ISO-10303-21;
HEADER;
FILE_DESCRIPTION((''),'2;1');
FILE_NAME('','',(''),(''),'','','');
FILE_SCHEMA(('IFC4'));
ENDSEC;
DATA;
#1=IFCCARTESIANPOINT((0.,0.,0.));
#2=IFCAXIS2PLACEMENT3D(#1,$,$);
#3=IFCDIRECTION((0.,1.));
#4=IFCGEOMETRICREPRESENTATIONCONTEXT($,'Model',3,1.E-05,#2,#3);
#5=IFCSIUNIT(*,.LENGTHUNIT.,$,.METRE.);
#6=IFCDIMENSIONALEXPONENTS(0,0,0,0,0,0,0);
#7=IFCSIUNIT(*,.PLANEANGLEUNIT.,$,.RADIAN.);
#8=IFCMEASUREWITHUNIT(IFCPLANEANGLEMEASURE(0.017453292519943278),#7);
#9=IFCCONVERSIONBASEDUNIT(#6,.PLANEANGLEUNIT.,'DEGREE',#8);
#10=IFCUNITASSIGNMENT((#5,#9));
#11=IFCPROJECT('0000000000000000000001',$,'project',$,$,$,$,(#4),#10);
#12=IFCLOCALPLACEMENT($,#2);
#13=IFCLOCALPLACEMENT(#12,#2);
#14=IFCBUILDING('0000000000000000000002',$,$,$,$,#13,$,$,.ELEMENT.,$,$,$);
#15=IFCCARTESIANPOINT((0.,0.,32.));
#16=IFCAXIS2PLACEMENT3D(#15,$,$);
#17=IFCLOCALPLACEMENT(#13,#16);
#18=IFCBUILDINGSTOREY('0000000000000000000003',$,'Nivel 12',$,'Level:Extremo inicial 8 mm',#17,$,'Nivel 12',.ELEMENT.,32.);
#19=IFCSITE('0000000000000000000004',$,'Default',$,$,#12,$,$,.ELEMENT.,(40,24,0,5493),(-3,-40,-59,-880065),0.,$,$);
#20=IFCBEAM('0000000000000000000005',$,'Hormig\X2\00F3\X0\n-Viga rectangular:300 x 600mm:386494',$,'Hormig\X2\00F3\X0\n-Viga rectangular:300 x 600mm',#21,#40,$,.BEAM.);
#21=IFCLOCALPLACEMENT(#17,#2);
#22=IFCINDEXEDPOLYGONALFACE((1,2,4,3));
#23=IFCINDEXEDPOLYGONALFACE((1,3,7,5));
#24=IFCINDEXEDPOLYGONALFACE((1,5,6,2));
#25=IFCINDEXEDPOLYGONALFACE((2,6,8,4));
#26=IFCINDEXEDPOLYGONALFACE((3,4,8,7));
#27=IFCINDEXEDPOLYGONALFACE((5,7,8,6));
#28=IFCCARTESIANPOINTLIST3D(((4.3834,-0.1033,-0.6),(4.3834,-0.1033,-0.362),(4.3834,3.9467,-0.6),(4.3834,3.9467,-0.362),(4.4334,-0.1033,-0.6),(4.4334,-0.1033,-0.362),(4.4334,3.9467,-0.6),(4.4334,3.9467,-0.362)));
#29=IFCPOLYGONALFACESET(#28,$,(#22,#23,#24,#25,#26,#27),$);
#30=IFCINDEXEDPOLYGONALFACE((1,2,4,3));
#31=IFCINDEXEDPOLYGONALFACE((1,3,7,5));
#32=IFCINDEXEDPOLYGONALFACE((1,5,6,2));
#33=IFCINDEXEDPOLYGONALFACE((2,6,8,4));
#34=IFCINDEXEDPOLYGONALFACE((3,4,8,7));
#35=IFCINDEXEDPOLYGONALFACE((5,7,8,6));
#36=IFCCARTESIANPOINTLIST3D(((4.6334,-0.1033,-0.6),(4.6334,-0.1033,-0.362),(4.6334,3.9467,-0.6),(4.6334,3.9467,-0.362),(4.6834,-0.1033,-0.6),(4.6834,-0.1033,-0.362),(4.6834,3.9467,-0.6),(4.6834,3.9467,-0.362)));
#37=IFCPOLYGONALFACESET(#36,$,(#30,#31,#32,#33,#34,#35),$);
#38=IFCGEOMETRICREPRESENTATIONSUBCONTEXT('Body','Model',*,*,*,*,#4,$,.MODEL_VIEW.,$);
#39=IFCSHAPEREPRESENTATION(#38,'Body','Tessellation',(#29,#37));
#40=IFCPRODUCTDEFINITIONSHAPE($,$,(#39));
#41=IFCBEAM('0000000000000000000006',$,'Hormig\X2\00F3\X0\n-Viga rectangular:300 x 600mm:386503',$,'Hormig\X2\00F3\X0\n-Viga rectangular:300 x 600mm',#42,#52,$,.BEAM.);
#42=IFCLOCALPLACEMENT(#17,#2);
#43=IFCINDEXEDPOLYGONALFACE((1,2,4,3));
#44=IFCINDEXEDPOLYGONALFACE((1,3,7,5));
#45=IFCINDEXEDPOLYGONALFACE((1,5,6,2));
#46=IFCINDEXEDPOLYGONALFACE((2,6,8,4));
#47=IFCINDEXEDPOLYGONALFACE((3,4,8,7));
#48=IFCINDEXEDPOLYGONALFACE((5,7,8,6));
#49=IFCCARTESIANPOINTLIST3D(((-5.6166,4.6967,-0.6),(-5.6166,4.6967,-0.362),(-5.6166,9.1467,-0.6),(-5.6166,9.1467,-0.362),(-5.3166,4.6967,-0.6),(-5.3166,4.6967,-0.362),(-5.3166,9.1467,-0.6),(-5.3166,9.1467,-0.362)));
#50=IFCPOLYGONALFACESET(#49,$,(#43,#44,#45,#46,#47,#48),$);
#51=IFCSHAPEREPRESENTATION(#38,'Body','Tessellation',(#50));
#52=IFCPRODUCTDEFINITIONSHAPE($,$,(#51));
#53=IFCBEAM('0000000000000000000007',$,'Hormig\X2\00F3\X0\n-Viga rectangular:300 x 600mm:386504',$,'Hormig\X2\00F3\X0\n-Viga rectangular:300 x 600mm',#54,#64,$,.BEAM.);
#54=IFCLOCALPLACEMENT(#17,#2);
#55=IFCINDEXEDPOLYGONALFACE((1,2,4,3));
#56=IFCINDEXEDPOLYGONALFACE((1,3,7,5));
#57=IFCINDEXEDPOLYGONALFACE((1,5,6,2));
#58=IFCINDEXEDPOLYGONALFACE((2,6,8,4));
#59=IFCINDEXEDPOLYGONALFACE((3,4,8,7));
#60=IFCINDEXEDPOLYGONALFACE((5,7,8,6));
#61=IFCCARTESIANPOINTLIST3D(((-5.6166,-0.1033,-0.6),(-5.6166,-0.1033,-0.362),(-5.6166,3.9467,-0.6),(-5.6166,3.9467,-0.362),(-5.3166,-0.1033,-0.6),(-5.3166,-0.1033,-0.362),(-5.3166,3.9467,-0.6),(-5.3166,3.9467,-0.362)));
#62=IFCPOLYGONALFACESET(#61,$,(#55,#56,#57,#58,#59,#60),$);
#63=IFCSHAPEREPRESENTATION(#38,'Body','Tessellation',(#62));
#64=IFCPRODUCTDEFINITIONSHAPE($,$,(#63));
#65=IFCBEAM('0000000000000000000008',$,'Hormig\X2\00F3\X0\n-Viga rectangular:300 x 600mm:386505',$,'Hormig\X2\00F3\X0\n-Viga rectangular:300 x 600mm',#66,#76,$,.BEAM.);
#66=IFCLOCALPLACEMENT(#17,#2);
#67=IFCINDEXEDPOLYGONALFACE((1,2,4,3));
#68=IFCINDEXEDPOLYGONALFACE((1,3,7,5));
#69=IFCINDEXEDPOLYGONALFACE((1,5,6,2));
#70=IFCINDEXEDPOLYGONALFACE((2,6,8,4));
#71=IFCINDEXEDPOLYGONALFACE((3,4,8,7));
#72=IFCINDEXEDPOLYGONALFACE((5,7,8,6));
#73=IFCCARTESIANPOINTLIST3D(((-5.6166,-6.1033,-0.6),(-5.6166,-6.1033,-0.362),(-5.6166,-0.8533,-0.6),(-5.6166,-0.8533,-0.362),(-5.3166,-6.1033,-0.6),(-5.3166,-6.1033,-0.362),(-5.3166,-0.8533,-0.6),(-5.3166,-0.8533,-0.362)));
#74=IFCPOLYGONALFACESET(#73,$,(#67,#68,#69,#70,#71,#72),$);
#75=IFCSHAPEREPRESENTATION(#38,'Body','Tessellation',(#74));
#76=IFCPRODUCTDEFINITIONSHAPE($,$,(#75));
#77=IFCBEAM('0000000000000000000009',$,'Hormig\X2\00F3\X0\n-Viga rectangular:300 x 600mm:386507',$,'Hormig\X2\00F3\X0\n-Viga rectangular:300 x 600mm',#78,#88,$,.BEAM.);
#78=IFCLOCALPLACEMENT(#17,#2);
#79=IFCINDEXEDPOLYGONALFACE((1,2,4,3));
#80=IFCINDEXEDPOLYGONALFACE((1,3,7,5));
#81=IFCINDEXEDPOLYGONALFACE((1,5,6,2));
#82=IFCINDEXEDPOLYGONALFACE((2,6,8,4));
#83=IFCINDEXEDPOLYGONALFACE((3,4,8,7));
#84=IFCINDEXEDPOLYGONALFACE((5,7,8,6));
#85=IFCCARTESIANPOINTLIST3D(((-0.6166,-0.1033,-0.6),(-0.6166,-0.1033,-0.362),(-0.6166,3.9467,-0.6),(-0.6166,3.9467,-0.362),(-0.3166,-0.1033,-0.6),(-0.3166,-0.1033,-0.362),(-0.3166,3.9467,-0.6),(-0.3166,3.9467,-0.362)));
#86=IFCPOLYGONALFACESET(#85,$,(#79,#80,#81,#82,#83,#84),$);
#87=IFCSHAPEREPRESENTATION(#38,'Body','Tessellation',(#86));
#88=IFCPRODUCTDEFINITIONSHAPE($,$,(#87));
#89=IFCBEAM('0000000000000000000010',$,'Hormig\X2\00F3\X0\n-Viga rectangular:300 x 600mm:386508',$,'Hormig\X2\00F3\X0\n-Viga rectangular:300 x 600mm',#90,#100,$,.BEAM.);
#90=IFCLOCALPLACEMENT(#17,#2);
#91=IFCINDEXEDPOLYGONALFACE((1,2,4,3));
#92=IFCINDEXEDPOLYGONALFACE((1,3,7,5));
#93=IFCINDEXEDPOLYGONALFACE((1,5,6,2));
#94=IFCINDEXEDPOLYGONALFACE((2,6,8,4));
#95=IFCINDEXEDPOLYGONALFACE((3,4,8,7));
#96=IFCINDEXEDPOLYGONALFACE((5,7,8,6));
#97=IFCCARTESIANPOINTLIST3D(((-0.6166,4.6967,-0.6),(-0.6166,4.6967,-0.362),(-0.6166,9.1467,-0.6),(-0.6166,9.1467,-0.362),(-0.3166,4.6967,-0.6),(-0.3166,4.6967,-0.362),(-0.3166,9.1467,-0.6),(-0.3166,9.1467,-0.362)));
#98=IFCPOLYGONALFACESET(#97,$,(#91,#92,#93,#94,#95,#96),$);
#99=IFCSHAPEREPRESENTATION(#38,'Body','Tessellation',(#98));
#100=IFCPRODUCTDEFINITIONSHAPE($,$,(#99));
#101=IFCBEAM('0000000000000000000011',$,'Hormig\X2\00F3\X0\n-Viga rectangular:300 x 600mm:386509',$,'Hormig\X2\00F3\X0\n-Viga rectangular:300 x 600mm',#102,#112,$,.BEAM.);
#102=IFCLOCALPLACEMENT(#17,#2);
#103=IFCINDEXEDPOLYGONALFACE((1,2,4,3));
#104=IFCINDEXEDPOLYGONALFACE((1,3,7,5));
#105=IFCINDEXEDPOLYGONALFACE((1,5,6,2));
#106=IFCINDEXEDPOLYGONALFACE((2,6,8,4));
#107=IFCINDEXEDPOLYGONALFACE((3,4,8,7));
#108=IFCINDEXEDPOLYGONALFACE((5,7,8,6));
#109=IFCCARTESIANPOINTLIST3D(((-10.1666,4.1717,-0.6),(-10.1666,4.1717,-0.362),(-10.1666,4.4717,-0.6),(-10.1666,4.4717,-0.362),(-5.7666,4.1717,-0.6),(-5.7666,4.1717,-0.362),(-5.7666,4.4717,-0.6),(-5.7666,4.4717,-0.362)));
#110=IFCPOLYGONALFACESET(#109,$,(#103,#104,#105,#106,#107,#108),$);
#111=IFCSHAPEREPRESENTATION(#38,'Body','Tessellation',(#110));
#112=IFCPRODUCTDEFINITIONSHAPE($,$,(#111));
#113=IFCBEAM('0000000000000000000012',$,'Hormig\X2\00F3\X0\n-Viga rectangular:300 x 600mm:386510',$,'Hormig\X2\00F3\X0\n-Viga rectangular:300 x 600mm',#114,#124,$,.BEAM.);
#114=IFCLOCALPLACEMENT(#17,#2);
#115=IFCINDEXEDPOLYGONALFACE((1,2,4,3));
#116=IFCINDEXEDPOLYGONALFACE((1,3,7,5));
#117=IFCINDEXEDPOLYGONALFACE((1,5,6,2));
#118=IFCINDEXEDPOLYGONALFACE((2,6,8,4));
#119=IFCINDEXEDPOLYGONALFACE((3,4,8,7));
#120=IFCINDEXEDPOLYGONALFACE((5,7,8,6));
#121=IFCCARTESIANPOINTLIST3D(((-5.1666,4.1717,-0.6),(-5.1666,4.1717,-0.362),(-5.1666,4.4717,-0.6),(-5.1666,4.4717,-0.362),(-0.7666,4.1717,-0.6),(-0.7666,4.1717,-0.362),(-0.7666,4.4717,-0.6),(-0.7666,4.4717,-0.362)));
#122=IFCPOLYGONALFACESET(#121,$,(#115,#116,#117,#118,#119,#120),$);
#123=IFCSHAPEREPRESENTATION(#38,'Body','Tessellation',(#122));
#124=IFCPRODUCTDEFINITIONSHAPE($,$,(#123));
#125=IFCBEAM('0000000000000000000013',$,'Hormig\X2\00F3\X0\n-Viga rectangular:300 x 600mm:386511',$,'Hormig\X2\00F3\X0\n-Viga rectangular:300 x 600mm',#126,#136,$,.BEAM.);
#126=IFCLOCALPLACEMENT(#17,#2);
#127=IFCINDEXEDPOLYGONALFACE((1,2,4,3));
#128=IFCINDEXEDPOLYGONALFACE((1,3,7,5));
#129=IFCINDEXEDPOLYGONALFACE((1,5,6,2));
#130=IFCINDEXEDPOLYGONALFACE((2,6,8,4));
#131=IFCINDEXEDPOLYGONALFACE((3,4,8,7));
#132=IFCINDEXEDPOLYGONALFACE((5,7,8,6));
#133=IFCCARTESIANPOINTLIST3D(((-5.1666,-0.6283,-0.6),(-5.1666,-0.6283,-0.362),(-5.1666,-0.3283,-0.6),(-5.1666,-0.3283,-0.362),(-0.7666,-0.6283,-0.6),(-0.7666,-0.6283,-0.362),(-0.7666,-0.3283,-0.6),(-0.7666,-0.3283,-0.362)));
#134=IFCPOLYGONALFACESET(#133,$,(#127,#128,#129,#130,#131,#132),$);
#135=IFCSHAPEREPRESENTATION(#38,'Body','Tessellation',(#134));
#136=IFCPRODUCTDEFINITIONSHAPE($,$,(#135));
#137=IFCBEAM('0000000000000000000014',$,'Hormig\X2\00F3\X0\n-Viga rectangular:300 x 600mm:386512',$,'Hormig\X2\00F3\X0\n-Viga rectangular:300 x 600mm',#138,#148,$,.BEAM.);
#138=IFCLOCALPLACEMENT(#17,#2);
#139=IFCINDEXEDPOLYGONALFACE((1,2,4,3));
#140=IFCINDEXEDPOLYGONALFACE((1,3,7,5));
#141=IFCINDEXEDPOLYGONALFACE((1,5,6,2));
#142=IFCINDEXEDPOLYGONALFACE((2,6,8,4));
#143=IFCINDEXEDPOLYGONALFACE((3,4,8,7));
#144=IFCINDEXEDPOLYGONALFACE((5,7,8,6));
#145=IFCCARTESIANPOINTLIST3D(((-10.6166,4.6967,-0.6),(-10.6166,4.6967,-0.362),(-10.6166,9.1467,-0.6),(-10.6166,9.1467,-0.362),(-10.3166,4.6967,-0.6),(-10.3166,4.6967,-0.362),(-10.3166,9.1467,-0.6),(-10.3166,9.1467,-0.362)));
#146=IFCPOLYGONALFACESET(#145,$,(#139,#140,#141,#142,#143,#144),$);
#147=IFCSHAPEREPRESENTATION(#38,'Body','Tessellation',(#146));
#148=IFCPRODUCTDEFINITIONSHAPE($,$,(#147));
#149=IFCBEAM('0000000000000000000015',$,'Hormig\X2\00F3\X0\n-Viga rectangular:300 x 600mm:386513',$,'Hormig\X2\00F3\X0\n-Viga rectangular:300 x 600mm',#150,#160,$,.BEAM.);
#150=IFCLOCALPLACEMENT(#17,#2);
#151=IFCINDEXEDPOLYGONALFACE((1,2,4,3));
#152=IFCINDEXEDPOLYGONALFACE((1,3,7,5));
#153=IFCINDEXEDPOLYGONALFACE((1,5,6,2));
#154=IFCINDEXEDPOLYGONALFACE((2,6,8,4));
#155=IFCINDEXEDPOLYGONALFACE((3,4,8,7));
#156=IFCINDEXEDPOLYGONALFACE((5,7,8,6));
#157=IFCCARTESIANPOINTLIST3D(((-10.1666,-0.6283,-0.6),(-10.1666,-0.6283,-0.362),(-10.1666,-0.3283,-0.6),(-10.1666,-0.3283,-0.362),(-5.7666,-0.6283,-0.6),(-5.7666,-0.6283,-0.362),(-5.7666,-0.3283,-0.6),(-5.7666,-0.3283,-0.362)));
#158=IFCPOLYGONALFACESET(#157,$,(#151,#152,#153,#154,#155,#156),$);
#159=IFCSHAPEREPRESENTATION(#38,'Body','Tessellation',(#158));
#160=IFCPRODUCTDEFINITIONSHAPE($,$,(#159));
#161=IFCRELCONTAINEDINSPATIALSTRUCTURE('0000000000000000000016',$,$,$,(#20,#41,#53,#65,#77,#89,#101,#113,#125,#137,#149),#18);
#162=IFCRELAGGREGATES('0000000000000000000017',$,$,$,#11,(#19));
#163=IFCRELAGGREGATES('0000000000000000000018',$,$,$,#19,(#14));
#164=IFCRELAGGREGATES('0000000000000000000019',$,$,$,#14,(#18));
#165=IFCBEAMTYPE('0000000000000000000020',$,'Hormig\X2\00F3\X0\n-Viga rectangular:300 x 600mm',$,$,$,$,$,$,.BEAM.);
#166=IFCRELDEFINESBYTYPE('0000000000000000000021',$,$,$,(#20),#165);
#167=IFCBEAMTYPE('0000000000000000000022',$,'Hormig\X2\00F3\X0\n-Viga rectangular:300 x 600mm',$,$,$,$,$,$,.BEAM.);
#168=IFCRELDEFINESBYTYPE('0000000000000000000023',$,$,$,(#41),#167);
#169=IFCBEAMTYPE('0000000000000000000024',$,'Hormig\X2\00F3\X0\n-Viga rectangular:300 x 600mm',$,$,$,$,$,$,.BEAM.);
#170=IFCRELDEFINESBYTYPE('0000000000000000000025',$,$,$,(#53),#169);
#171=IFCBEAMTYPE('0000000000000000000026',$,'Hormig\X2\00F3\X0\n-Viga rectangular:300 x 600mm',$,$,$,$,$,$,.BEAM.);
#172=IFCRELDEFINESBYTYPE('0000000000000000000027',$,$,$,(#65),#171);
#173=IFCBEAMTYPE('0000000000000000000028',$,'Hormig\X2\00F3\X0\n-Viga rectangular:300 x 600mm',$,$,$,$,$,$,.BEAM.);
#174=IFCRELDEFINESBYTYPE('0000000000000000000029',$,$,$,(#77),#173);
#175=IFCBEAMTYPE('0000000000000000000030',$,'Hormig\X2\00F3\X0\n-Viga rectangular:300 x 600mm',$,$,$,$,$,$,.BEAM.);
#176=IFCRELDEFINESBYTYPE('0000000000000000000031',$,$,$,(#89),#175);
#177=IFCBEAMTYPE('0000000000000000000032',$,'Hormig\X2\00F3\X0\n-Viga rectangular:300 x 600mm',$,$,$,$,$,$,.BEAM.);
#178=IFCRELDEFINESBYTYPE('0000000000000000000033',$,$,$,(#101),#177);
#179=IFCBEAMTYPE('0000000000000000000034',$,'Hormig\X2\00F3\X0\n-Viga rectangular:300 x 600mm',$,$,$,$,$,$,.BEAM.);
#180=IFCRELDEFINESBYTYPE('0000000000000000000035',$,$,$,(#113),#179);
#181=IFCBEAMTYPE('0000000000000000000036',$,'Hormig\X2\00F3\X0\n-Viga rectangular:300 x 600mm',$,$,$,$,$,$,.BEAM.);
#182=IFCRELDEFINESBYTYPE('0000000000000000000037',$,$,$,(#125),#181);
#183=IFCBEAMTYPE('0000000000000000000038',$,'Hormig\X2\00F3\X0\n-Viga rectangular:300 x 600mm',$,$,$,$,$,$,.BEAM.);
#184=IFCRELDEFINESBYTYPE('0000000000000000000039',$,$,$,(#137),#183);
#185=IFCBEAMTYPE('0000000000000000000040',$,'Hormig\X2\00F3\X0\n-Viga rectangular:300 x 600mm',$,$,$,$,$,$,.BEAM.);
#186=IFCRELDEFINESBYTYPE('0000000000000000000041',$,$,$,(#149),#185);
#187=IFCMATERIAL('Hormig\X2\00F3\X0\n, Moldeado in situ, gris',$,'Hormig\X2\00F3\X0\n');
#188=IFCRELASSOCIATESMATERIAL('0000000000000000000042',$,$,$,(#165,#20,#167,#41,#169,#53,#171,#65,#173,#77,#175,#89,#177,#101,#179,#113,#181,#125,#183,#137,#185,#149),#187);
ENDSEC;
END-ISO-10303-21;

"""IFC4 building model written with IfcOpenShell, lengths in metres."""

from ifc_helpers import new_model, entity, si_unit, converted_unit, direction, frame, origin, place, context, subcontext, project, spatial, indexed_curve, outline, extrude, source, transform, mapped, material, type_object, type_shapes, element, save


model = new_model("IFC4")

# Units and contexts
model_context = context("Model", 3, precision=1e-05, world=origin(), true_north=direction((0.0, 1.0)))
body_context = subcontext(model_context, "Body", "Model", "MODEL_VIEW")
ifc_project = project(units=[si_unit("LENGTHUNIT", "METRE"), converted_unit("PLANEANGLEUNIT", "DEGREE", entity("IfcPlaneAngleMeasure", 0.017453292519943278), si_unit("PLANEANGLEUNIT", "RADIAN"), dimensions=[0, 0, 0, 0, 0, 0, 0])], contexts=[model_context])

# Site, building, storey
site_placement = place(None, origin())
site = spatial("IfcSite", under=ifc_project, at=site_placement, Name="Default", CompositionType="ELEMENT", RefLatitude=(40, 24, 0, 5493), RefLongitude=(-3, -40, -59, -880065), RefElevation=0.0)
building_placement = place(site_placement, origin())
building = spatial("IfcBuilding", under=site, at=building_placement, CompositionType="ELEMENT")
storey_placement = place(building_placement, frame((0.0, 0.0, 32.0)))
storey = spatial("IfcBuildingStorey", under=building, at=storey_placement, Name="Nivel 12", ObjectType="Level:Extremo inicial 8 mm", LongName="Nivel 12", CompositionType="ELEMENT", Elevation=32.0)

# Shared definitions
ifc_material_1 = material(Name="Hormigón, Moldeado in situ, gris", Category="Hormigón")

# Beams
beam_type_1 = type_object("IfcBeamType", Name="Hormigón-Viga rectangular:300 x 600mm", PredefinedType="BEAM", material=ifc_material_1)
shared_shape_1 = source(origin(), body_context, "Body", "SweptSolid", [
    extrude(outline(indexed_curve([(-0.025, -0.119), (0.025, -0.119), (0.025, 0.119), (-0.025, 0.119), (-0.025, -0.119)], self_intersect=False)), frame((4.4084, 3.9467, 31.519), z_axis=(0.0, -1.0, 0.0), x_axis=(-1.0, 0.0, 0.0)), (0.0, 0.0, 1.0), 4.05),
    extrude(outline(indexed_curve([(-0.025, -0.119), (0.025, -0.119), (0.025, 0.119), (-0.025, 0.119), (-0.025, -0.119)], self_intersect=False)), frame((4.6584, 3.9467, 31.519), z_axis=(0.0, -1.0, 0.0), x_axis=(-1.0, 0.0, 0.0)), (0.0, 0.0, 1.0), 4.05),
])
type_shapes(beam_type_1, [shared_shape_1])
beam_1_placement = place(storey_placement, frame((0.0, 0.0, -32.0)))
element("IfcBeam", 1, at=beam_1_placement, inside=storey, type_object=beam_type_1, material=ifc_material_1, Name="Hormigón-Viga rectangular:300 x 600mm:386494", ObjectType="Hormigón-Viga rectangular:300 x 600mm", PredefinedType="BEAM", context=body_context, shape_type="MappedRepresentation", body=[
    mapped(shared_shape_1, transform((0.0, 0.0, 0.0), scale=1.0)),
])
beam_type_2 = type_object("IfcBeamType", Name="Hormigón-Viga rectangular:300 x 600mm", PredefinedType="BEAM", material=ifc_material_1)
shared_shape_2 = source(origin(), body_context, "Body", "SweptSolid", [
    extrude(outline(indexed_curve([(-0.15, -0.119), (0.15, -0.119), (0.15, 0.119), (-0.15, 0.119), (-0.15, -0.119)], self_intersect=False)), frame((-5.4666, 9.1467, 31.519), z_axis=(0.0, -1.0, 0.0), x_axis=(-1.0, 0.0, 0.0)), (0.0, 0.0, 1.0), 4.45),
])
type_shapes(beam_type_2, [shared_shape_2])
beam_2_placement = place(storey_placement, frame((0.0, 0.0, -32.0)))
element("IfcBeam", 2, at=beam_2_placement, inside=storey, type_object=beam_type_2, material=ifc_material_1, Name="Hormigón-Viga rectangular:300 x 600mm:386503", ObjectType="Hormigón-Viga rectangular:300 x 600mm", PredefinedType="BEAM", context=body_context, shape_type="MappedRepresentation", body=[
    mapped(shared_shape_2, transform((0.0, 0.0, 0.0), scale=1.0)),
])
beam_type_3 = type_object("IfcBeamType", Name="Hormigón-Viga rectangular:300 x 600mm", PredefinedType="BEAM", material=ifc_material_1)
shared_shape_3 = source(origin(), body_context, "Body", "SweptSolid", [
    extrude(outline(indexed_curve([(-0.15, -0.119), (0.15, -0.119), (0.15, 0.119), (-0.15, 0.119), (-0.15, -0.119)], self_intersect=False)), frame((-5.4666, 3.9467, 31.519), z_axis=(0.0, -1.0, 0.0), x_axis=(-1.0, 0.0, 0.0)), (0.0, 0.0, 1.0), 4.05),
])
type_shapes(beam_type_3, [shared_shape_3])
beam_3_placement = place(storey_placement, frame((0.0, 0.0, -32.0)))
element("IfcBeam", 3, at=beam_3_placement, inside=storey, type_object=beam_type_3, material=ifc_material_1, Name="Hormigón-Viga rectangular:300 x 600mm:386504", ObjectType="Hormigón-Viga rectangular:300 x 600mm", PredefinedType="BEAM", context=body_context, shape_type="MappedRepresentation", body=[
    mapped(shared_shape_3, transform((0.0, 0.0, 0.0), scale=1.0)),
])
beam_type_4 = type_object("IfcBeamType", Name="Hormigón-Viga rectangular:300 x 600mm", PredefinedType="BEAM", material=ifc_material_1)
shared_shape_4 = source(origin(), body_context, "Body", "SweptSolid", [
    extrude(outline(indexed_curve([(-0.15, -0.119), (0.15, -0.119), (0.15, 0.119), (-0.15, 0.119), (-0.15, -0.119)], self_intersect=False)), frame((-5.4666, -6.1033, 31.519), z_axis=(0.0, 1.0, 0.0), x_axis=(-1.0, 0.0, 0.0)), (0.0, 0.0, 1.0), 5.25),
])
type_shapes(beam_type_4, [shared_shape_4])
beam_4_placement = place(storey_placement, frame((0.0, 0.0, -32.0)))
element("IfcBeam", 4, at=beam_4_placement, inside=storey, type_object=beam_type_4, material=ifc_material_1, Name="Hormigón-Viga rectangular:300 x 600mm:386505", ObjectType="Hormigón-Viga rectangular:300 x 600mm", PredefinedType="BEAM", context=body_context, shape_type="MappedRepresentation", body=[
    mapped(shared_shape_4, transform((0.0, 0.0, 0.0), scale=1.0)),
])
beam_type_5 = type_object("IfcBeamType", Name="Hormigón-Viga rectangular:300 x 600mm", PredefinedType="BEAM", material=ifc_material_1)
shared_shape_5 = source(origin(), body_context, "Body", "SweptSolid", [
    extrude(outline(indexed_curve([(-0.15, -0.119), (0.15, -0.119), (0.15, 0.119), (-0.15, 0.119), (-0.15, -0.119)], self_intersect=False)), frame((-0.4666, -0.1033, 31.519), z_axis=(0.0, 1.0, 0.0), x_axis=(-1.0, 0.0, 0.0)), (0.0, 0.0, 1.0), 4.05),
])
type_shapes(beam_type_5, [shared_shape_5])
beam_5_placement = place(storey_placement, frame((0.0, 0.0, -32.0)))
element("IfcBeam", 5, at=beam_5_placement, inside=storey, type_object=beam_type_5, material=ifc_material_1, Name="Hormigón-Viga rectangular:300 x 600mm:386507", ObjectType="Hormigón-Viga rectangular:300 x 600mm", PredefinedType="BEAM", context=body_context, shape_type="MappedRepresentation", body=[
    mapped(shared_shape_5, transform((0.0, 0.0, 0.0), scale=1.0)),
])
beam_type_6 = type_object("IfcBeamType", Name="Hormigón-Viga rectangular:300 x 600mm", PredefinedType="BEAM", material=ifc_material_1)
shared_shape_6 = source(origin(), body_context, "Body", "SweptSolid", [
    extrude(outline(indexed_curve([(-0.15, -0.119), (0.15, -0.119), (0.15, 0.119), (-0.15, 0.119), (-0.15, -0.119)], self_intersect=False)), frame((-0.4666, 9.1467, 31.519), z_axis=(0.0, -1.0, 0.0), x_axis=(-1.0, 0.0, 0.0)), (0.0, 0.0, 1.0), 4.45),
])
type_shapes(beam_type_6, [shared_shape_6])
beam_6_placement = place(storey_placement, frame((0.0, 0.0, -32.0)))
element("IfcBeam", 6, at=beam_6_placement, inside=storey, type_object=beam_type_6, material=ifc_material_1, Name="Hormigón-Viga rectangular:300 x 600mm:386508", ObjectType="Hormigón-Viga rectangular:300 x 600mm", PredefinedType="BEAM", context=body_context, shape_type="MappedRepresentation", body=[
    mapped(shared_shape_6, transform((0.0, 0.0, 0.0), scale=1.0)),
])
beam_type_7 = type_object("IfcBeamType", Name="Hormigón-Viga rectangular:300 x 600mm", PredefinedType="BEAM", material=ifc_material_1)
shared_shape_7 = source(origin(), body_context, "Body", "SweptSolid", [
    extrude(outline(indexed_curve([(-0.119, -0.15), (0.119, -0.15), (0.119, 0.15), (-0.119, 0.15), (-0.119, -0.15)], self_intersect=False)), frame((-10.1666, 4.3217, 31.519), z_axis=(1.0, 0.0, 0.0), x_axis=(0.0, 0.0, -1.0)), (0.0, 0.0, 1.0), 4.4),
])
type_shapes(beam_type_7, [shared_shape_7])
beam_7_placement = place(storey_placement, frame((0.0, 0.0, -32.0)))
element("IfcBeam", 7, at=beam_7_placement, inside=storey, type_object=beam_type_7, material=ifc_material_1, Name="Hormigón-Viga rectangular:300 x 600mm:386509", ObjectType="Hormigón-Viga rectangular:300 x 600mm", PredefinedType="BEAM", context=body_context, shape_type="MappedRepresentation", body=[
    mapped(shared_shape_7, transform((0.0, 0.0, 0.0), scale=1.0)),
])
beam_type_8 = type_object("IfcBeamType", Name="Hormigón-Viga rectangular:300 x 600mm", PredefinedType="BEAM", material=ifc_material_1)
shared_shape_8 = source(origin(), body_context, "Body", "SweptSolid", [
    extrude(outline(indexed_curve([(-0.119, -0.15), (0.119, -0.15), (0.119, 0.15), (-0.119, 0.15), (-0.119, -0.15)], self_intersect=False)), frame((-5.1666, 4.3217, 31.519), z_axis=(1.0, 0.0, 0.0), x_axis=(0.0, 0.0, -1.0)), (0.0, 0.0, 1.0), 4.4),
])
type_shapes(beam_type_8, [shared_shape_8])
beam_8_placement = place(storey_placement, frame((0.0, 0.0, -32.0)))
element("IfcBeam", 8, at=beam_8_placement, inside=storey, type_object=beam_type_8, material=ifc_material_1, Name="Hormigón-Viga rectangular:300 x 600mm:386510", ObjectType="Hormigón-Viga rectangular:300 x 600mm", PredefinedType="BEAM", context=body_context, shape_type="MappedRepresentation", body=[
    mapped(shared_shape_8, transform((0.0, 0.0, 0.0), scale=1.0)),
])
beam_type_9 = type_object("IfcBeamType", Name="Hormigón-Viga rectangular:300 x 600mm", PredefinedType="BEAM", material=ifc_material_1)
shared_shape_9 = source(origin(), body_context, "Body", "SweptSolid", [
    extrude(outline(indexed_curve([(-0.119, -0.15), (0.119, -0.15), (0.119, 0.15), (-0.119, 0.15), (-0.119, -0.15)], self_intersect=False)), frame((-0.7666, -0.4783, 31.519), z_axis=(-1.0, 0.0, 0.0), x_axis=(0.0, 0.0, -1.0)), (0.0, 0.0, 1.0), 4.4),
])
type_shapes(beam_type_9, [shared_shape_9])
beam_9_placement = place(storey_placement, frame((0.0, 0.0, -32.0)))
element("IfcBeam", 9, at=beam_9_placement, inside=storey, type_object=beam_type_9, material=ifc_material_1, Name="Hormigón-Viga rectangular:300 x 600mm:386511", ObjectType="Hormigón-Viga rectangular:300 x 600mm", PredefinedType="BEAM", context=body_context, shape_type="MappedRepresentation", body=[
    mapped(shared_shape_9, transform((0.0, 0.0, 0.0), scale=1.0)),
])
beam_type_10 = type_object("IfcBeamType", Name="Hormigón-Viga rectangular:300 x 600mm", PredefinedType="BEAM", material=ifc_material_1)
shared_shape_10 = source(origin(), body_context, "Body", "SweptSolid", [
    extrude(outline(indexed_curve([(-0.15, -0.119), (0.15, -0.119), (0.15, 0.119), (-0.15, 0.119), (-0.15, -0.119)], self_intersect=False)), frame((-10.4666, 4.6967, 31.519), z_axis=(0.0, 1.0, 0.0), x_axis=(-1.0, 0.0, 0.0)), (0.0, 0.0, 1.0), 4.45),
])
type_shapes(beam_type_10, [shared_shape_10])
beam_10_placement = place(storey_placement, frame((0.0, 0.0, -32.0)))
element("IfcBeam", 10, at=beam_10_placement, inside=storey, type_object=beam_type_10, material=ifc_material_1, Name="Hormigón-Viga rectangular:300 x 600mm:386512", ObjectType="Hormigón-Viga rectangular:300 x 600mm", PredefinedType="BEAM", context=body_context, shape_type="MappedRepresentation", body=[
    mapped(shared_shape_10, transform((0.0, 0.0, 0.0), scale=1.0)),
])
beam_type_11 = type_object("IfcBeamType", Name="Hormigón-Viga rectangular:300 x 600mm", PredefinedType="BEAM", material=ifc_material_1)
shared_shape_11 = source(origin(), body_context, "Body", "SweptSolid", [
    extrude(outline(indexed_curve([(-0.119, -0.15), (0.119, -0.15), (0.119, 0.15), (-0.119, 0.15), (-0.119, -0.15)], self_intersect=False)), frame((-10.1666, -0.4783, 31.519), z_axis=(1.0, 0.0, 0.0), x_axis=(0.0, 0.0, -1.0)), (0.0, 0.0, 1.0), 4.4),
])
type_shapes(beam_type_11, [shared_shape_11])
beam_11_placement = place(storey_placement, frame((0.0, 0.0, -32.0)))
element("IfcBeam", 11, at=beam_11_placement, inside=storey, type_object=beam_type_11, material=ifc_material_1, Name="Hormigón-Viga rectangular:300 x 600mm:386513", ObjectType="Hormigón-Viga rectangular:300 x 600mm", PredefinedType="BEAM", context=body_context, shape_type="MappedRepresentation", body=[
    mapped(shared_shape_11, transform((0.0, 0.0, 0.0), scale=1.0)),
])

save(model, "model.ifc")
